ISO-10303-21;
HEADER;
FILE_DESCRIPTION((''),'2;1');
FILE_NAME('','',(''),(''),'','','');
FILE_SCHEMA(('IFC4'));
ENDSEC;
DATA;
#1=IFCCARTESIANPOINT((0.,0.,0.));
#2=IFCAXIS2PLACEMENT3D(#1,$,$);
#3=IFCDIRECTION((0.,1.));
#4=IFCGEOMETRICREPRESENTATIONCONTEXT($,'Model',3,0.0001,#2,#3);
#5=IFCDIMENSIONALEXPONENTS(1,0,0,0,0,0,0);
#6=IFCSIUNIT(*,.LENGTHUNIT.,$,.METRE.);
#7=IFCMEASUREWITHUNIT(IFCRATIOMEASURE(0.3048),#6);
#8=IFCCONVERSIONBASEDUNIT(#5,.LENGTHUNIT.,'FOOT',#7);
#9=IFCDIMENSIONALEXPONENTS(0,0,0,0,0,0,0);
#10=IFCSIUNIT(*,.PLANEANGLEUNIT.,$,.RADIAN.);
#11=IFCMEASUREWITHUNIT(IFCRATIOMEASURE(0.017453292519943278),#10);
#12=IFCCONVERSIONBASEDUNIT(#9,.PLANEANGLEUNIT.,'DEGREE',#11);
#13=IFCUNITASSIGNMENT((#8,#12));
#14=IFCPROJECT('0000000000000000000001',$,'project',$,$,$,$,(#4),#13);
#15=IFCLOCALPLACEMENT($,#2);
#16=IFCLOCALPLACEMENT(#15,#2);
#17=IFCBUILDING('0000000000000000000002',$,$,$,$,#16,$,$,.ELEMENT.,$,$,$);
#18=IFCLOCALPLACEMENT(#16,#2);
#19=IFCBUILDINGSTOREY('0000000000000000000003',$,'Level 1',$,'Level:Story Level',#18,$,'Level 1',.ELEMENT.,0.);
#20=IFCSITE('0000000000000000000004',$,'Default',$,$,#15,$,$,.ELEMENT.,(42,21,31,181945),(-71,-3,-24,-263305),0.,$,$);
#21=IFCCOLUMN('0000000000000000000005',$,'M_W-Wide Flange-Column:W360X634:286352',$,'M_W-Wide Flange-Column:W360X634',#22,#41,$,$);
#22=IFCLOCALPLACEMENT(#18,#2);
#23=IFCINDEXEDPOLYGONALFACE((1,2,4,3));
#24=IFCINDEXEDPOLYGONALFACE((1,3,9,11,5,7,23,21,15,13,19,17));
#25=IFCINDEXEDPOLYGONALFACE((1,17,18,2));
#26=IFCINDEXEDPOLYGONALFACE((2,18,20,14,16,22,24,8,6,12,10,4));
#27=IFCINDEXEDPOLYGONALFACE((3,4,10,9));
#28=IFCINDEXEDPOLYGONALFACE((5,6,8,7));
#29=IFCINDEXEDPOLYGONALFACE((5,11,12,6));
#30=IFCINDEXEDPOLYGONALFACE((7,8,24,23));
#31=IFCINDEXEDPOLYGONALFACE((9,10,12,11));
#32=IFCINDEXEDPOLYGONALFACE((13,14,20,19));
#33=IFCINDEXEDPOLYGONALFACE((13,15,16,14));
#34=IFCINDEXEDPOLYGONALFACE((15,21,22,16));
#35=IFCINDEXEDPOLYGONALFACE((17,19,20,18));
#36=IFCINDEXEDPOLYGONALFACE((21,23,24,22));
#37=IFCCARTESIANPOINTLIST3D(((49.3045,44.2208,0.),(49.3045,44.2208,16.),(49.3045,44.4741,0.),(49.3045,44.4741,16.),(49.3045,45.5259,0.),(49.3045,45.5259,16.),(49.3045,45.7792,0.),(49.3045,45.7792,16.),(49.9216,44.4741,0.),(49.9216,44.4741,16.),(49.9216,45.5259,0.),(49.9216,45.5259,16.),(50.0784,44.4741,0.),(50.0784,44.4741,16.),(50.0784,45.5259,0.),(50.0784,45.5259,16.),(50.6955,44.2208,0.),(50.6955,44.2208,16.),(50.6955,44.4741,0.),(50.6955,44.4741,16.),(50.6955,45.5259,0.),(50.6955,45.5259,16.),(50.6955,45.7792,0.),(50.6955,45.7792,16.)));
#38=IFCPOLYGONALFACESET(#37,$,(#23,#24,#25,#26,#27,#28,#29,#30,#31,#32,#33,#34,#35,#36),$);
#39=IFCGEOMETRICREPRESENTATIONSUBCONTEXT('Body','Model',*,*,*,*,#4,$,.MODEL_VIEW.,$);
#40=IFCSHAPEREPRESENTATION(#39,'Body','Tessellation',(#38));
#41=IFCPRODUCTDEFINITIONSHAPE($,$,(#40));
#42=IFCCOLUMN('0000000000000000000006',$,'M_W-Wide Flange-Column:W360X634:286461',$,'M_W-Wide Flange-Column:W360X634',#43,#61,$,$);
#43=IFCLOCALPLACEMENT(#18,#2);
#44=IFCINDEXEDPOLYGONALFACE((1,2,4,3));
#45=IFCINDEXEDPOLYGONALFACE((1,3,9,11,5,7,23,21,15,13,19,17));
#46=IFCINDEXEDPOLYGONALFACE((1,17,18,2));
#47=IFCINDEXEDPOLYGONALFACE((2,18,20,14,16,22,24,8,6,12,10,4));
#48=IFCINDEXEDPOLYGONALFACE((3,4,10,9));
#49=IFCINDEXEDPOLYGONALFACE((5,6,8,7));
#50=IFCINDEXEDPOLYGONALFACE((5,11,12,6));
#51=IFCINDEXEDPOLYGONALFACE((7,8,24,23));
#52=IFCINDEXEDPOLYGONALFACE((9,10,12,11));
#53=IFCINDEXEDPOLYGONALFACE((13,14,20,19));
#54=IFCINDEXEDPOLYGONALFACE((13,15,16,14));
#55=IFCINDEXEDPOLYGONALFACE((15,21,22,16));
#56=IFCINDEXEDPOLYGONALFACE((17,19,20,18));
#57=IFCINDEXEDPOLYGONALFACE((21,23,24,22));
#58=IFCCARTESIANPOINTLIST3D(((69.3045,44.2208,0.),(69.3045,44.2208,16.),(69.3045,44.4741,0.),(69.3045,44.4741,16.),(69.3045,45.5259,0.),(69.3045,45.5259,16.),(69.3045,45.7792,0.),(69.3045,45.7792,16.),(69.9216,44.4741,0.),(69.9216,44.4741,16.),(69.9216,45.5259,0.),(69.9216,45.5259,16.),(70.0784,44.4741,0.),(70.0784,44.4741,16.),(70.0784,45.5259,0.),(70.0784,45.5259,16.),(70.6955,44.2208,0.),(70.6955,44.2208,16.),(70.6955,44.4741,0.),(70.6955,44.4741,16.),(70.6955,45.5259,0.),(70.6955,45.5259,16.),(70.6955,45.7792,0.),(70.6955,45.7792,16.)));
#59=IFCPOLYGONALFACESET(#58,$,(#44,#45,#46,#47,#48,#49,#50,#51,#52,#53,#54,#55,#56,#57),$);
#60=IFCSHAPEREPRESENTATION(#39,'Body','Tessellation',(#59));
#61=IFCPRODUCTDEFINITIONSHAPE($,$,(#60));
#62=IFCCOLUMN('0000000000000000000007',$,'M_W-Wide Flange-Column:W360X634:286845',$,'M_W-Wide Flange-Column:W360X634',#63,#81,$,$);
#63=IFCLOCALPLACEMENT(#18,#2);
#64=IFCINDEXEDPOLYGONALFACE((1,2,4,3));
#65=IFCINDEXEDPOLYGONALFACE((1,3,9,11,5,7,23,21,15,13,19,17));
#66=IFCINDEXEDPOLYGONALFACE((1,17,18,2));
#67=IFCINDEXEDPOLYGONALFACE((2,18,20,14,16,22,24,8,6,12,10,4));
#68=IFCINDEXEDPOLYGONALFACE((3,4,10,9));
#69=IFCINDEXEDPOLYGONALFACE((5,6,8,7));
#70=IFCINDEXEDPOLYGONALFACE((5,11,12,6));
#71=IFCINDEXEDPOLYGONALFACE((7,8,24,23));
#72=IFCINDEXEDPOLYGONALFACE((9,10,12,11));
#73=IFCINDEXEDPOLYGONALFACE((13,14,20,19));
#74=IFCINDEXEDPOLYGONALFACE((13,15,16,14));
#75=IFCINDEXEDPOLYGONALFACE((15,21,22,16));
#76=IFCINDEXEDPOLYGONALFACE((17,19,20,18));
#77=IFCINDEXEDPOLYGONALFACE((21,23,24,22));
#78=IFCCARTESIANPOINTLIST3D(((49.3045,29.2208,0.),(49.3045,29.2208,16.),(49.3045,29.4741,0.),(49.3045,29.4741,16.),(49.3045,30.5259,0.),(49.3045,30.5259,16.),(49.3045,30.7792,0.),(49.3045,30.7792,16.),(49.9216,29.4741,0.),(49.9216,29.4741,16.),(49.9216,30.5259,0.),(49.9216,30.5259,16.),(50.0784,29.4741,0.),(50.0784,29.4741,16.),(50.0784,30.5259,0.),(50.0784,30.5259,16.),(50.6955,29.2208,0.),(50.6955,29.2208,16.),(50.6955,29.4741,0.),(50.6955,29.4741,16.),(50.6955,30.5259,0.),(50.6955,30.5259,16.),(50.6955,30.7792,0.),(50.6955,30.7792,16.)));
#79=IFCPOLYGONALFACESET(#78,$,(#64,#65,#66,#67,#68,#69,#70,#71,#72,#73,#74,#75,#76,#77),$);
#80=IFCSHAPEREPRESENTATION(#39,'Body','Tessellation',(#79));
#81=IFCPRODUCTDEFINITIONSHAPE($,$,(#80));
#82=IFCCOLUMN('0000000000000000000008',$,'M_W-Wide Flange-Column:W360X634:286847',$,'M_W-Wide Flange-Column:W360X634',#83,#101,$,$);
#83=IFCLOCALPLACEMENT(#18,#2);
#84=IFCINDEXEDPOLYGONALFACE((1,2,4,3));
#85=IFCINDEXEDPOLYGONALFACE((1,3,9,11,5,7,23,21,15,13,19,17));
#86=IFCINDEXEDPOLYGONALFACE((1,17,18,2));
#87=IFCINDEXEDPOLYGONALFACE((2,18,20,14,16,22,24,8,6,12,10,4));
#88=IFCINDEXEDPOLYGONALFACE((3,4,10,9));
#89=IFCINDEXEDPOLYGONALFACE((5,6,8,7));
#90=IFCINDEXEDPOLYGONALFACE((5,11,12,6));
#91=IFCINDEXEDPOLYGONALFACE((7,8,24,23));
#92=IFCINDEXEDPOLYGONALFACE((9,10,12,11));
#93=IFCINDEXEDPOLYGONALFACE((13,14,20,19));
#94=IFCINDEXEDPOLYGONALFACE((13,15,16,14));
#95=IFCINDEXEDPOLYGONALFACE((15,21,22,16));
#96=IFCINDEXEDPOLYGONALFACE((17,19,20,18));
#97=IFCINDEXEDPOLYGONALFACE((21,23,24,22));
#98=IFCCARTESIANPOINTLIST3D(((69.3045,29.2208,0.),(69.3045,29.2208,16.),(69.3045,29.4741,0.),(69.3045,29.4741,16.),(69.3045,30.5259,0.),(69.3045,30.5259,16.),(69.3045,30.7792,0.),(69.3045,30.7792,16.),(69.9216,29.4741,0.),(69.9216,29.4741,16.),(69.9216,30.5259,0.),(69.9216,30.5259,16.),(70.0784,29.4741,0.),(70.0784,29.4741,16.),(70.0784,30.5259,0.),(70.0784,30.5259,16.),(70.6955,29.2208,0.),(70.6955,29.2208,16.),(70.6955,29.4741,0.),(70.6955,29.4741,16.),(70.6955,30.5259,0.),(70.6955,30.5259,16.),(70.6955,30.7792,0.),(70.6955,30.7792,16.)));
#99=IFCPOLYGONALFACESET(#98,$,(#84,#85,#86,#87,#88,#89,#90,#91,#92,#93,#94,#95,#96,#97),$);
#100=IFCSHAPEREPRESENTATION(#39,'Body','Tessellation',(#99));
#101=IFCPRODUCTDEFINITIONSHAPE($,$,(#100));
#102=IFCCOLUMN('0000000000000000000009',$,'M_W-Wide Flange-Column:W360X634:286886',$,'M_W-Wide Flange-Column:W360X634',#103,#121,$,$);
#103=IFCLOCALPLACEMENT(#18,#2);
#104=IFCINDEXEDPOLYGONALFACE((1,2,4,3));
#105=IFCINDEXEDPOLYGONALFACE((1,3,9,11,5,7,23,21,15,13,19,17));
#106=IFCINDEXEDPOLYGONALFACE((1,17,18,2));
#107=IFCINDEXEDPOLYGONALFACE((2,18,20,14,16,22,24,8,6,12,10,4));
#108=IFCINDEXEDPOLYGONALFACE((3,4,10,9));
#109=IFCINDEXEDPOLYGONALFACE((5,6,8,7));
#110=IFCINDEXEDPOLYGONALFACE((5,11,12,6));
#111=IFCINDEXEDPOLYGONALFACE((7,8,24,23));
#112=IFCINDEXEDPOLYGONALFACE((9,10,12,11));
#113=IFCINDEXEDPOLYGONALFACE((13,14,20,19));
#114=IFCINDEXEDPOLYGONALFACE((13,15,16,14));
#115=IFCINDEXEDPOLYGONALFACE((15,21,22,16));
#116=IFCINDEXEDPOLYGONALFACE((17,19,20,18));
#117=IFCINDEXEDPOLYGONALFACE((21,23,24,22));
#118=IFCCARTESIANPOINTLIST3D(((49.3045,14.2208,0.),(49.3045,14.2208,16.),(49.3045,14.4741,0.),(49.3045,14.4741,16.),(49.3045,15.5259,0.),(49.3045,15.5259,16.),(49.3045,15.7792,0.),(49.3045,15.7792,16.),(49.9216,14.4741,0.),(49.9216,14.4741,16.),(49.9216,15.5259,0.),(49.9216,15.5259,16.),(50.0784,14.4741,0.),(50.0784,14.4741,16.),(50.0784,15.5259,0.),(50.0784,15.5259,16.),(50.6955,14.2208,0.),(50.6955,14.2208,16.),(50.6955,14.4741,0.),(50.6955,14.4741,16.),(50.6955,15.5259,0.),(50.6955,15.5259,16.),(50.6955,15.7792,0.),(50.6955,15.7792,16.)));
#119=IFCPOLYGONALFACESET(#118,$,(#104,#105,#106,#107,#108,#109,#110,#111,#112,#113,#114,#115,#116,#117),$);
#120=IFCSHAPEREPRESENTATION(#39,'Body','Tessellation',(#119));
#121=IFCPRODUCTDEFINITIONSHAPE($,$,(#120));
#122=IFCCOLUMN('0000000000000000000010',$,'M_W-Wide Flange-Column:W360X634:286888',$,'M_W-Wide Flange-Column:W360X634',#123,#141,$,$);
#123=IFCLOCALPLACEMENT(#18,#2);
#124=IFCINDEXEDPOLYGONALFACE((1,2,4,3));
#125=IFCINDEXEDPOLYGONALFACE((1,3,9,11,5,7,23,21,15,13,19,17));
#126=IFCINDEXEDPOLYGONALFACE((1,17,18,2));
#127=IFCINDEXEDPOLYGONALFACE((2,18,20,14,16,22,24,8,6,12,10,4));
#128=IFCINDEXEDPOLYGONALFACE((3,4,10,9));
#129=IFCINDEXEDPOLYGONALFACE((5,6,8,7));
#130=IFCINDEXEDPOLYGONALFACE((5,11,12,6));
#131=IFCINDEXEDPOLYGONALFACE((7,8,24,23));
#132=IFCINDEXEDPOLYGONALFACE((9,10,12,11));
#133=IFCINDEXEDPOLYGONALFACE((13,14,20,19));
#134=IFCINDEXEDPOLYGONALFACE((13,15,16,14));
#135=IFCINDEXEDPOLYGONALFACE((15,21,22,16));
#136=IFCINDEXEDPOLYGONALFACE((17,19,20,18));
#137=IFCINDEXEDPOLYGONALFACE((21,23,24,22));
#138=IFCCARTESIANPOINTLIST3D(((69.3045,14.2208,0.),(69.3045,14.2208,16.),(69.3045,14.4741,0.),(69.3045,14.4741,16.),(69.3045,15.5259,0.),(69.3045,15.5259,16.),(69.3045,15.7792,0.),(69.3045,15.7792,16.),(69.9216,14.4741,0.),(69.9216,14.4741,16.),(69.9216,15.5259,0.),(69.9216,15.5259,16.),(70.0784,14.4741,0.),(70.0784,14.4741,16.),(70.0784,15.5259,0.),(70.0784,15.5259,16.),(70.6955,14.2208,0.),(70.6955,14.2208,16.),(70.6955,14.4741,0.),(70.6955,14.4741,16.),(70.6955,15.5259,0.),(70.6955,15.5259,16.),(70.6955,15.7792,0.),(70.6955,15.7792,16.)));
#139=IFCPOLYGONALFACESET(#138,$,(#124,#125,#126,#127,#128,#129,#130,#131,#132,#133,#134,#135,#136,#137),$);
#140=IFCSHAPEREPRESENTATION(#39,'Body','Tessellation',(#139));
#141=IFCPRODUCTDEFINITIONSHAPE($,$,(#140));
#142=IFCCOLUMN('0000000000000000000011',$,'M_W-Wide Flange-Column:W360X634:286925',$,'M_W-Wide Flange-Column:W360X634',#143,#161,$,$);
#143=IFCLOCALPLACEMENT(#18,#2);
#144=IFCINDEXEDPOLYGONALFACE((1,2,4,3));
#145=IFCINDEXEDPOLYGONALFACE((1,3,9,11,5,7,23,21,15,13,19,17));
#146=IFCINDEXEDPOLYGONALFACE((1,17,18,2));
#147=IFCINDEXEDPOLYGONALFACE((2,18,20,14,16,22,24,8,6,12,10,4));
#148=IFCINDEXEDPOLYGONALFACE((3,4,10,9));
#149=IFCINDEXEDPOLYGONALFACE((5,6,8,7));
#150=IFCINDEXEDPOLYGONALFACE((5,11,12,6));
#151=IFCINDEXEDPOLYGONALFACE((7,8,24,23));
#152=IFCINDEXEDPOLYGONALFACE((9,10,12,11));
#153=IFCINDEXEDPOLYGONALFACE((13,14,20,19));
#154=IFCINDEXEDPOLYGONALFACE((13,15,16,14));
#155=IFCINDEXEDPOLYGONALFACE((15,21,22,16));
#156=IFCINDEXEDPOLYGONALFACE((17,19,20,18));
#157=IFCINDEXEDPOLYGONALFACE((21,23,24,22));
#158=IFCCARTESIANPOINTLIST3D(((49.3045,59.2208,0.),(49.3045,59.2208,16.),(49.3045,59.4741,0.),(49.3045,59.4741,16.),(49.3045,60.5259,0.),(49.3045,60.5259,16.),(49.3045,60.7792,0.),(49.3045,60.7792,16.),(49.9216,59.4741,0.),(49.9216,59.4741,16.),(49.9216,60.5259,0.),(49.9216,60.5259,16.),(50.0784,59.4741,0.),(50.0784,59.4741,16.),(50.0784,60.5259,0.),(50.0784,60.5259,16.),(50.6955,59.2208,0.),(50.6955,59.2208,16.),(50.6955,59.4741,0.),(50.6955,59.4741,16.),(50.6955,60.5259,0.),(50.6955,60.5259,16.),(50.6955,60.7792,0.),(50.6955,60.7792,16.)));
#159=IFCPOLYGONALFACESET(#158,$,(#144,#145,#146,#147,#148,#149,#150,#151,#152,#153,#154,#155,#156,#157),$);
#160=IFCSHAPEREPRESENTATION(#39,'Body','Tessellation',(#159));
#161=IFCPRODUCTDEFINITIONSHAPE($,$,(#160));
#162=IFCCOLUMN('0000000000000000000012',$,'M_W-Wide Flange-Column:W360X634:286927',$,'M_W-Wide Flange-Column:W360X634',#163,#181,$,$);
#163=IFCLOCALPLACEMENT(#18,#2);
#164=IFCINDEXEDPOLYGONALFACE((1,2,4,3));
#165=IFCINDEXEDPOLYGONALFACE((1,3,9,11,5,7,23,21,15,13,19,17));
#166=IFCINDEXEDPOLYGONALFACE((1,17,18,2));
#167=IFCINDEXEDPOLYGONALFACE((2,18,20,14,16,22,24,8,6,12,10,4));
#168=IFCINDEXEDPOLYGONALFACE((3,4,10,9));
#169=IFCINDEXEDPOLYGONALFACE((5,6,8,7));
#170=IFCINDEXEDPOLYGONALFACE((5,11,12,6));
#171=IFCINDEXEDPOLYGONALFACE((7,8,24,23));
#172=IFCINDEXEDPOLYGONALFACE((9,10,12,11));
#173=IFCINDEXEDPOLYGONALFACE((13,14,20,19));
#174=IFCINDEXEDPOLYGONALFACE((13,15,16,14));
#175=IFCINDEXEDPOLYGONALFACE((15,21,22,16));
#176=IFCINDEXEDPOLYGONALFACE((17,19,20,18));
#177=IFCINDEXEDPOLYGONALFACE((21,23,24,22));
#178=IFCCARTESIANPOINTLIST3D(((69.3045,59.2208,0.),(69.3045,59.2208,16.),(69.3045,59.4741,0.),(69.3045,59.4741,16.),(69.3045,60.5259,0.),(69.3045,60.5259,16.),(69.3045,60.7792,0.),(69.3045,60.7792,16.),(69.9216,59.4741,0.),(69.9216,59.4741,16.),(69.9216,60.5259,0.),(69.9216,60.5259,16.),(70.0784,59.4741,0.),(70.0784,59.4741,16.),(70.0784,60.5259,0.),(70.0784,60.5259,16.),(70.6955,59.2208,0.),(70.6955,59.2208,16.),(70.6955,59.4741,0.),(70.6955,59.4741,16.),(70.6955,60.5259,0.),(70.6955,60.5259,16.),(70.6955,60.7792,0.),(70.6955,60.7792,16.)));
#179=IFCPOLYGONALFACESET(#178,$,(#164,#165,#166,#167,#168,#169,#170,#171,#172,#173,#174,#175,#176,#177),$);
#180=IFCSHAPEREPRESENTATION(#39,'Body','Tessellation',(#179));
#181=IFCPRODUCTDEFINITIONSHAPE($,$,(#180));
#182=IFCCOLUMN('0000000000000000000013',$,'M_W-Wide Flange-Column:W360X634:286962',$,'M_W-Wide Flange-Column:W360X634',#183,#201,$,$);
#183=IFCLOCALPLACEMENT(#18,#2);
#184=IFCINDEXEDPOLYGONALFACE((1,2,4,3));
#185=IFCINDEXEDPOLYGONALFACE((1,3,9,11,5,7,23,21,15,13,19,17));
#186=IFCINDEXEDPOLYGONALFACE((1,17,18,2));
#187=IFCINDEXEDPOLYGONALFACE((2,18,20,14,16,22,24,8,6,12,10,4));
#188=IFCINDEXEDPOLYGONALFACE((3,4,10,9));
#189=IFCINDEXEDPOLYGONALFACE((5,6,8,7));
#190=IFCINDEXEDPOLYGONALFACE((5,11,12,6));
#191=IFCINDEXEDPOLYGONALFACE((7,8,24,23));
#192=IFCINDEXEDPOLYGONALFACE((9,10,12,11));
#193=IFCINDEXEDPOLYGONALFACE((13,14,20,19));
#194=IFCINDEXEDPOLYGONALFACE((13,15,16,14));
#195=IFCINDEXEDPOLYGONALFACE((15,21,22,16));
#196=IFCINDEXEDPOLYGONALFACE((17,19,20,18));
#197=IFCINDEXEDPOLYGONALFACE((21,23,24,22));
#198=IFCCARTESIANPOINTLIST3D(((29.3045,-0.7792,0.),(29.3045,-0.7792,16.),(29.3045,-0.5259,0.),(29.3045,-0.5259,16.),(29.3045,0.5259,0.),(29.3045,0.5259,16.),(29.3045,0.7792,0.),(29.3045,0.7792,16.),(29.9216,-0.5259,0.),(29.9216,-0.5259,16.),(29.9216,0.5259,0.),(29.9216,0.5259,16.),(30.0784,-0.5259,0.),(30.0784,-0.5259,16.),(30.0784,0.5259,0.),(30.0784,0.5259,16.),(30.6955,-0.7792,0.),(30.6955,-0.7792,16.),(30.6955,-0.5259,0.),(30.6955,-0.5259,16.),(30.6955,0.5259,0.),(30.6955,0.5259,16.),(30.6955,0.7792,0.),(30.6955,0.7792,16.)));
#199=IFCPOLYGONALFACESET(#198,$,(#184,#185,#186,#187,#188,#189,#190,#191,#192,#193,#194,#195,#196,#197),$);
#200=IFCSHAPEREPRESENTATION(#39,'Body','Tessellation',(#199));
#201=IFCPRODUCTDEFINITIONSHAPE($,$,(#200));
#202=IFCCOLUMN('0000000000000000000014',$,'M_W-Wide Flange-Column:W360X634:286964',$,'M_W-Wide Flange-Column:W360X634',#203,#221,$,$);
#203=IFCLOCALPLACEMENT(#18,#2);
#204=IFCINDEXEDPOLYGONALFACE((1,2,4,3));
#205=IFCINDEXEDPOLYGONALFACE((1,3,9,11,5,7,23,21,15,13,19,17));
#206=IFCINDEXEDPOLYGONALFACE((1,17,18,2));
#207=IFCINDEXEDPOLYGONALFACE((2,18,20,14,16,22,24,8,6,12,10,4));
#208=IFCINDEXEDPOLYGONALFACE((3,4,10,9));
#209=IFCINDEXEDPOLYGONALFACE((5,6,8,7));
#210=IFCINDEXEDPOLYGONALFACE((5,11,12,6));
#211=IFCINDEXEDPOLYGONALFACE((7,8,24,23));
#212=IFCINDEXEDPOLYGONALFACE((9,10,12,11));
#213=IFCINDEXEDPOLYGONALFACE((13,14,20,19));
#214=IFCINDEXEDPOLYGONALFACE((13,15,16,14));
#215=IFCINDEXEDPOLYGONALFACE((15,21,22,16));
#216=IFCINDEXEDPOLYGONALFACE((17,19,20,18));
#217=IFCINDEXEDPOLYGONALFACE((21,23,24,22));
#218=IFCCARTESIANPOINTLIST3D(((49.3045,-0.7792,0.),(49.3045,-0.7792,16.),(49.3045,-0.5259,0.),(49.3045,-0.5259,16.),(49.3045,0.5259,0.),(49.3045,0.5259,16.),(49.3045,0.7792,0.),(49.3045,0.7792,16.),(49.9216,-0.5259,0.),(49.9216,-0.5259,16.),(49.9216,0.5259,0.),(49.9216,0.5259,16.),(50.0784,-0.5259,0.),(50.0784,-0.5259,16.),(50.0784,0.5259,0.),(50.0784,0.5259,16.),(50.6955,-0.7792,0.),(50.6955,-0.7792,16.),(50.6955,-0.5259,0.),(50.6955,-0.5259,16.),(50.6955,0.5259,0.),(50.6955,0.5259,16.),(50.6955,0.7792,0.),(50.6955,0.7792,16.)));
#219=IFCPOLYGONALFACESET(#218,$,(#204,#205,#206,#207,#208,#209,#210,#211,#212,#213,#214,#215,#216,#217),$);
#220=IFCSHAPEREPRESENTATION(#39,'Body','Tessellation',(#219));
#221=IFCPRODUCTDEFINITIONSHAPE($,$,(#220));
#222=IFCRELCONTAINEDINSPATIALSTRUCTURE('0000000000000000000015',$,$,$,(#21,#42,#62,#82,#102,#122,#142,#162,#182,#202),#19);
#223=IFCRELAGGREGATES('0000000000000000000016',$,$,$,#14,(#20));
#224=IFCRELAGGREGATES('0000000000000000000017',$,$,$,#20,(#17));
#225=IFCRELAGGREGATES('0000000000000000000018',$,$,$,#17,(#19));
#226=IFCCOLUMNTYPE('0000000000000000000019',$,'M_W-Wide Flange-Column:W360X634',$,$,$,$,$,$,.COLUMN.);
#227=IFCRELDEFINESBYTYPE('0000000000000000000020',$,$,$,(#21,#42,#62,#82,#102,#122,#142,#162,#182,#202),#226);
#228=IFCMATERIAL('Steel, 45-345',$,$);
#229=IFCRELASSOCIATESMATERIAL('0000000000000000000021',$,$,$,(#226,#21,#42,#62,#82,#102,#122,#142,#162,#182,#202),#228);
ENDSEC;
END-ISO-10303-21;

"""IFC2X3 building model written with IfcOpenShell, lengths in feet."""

from ifc_helpers import new_model, entity, si_unit, converted_unit, direction, frame, origin, place, context, subcontext, project, spatial, polyline, outline, extrude, source, transform, mapped, material, type_object, type_shapes, element, save


model = new_model("IFC2X3")

# Units and contexts
model_context = context("Model", 3, precision=0.0001, world=origin(), true_north=direction((0.0, 1.0)))
body_context = subcontext(model_context, "Body", "Model", "MODEL_VIEW")
ifc_project = project(units=[converted_unit("LENGTHUNIT", "FOOT", entity("IfcRatioMeasure", 0.3048), si_unit("LENGTHUNIT", "METRE"), dimensions=[1, 0, 0, 0, 0, 0, 0]), converted_unit("PLANEANGLEUNIT", "DEGREE", entity("IfcRatioMeasure", 0.017453292519943278), si_unit("PLANEANGLEUNIT", "RADIAN"), dimensions=[0, 0, 0, 0, 0, 0, 0])], contexts=[model_context])

# Site, building, storey
site_placement = place(None, origin())
site = spatial("IfcSite", under=ifc_project, at=site_placement, Name="Default", CompositionType="ELEMENT", RefLatitude=(42, 21, 31, 181945), RefLongitude=(-71, -3, -24, -263305), RefElevation=0.0)
building_placement = place(site_placement, origin())
building = spatial("IfcBuilding", under=site, at=building_placement, CompositionType="ELEMENT")
storey_placement = place(building_placement, origin())
storey = spatial("IfcBuildingStorey", under=building, at=storey_placement, Name="Level 1", ObjectType="Level:Story Level", LongName="Level 1", CompositionType="ELEMENT", Elevation=0.0)

# Columns
ifc_material = material(Name="Steel, 45-345")
column_type = type_object("IfcColumnType", Name="M_W-Wide Flange-Column:W360X634", PredefinedType="COLUMN", material=ifc_material)
shared_shape = source(origin(), body_context, "Body", "SweptSolid", [
    extrude(outline(polyline([(0.5259, -0.6955), (0.7792, -0.6955), (0.7792, 0.6955), (0.5259, 0.6955), (0.5259, 0.0784), (-0.5259, 0.0784), (-0.5259, 0.6955), (-0.7792, 0.6955), (-0.7792, -0.6955), (-0.5259, -0.6955), (-0.5259, -0.0784), (0.5259, -0.0784), (0.5259, -0.6955)])), frame((0.0, 0.0, 0.0), z_axis=(0.0, 0.0, 1.0), x_axis=(0.0, -1.0, 0.0)), (0.0, 0.0, 1.0), 16.0),
])
type_shapes(column_type, [shared_shape])
for number, where, name in (
    (1, (50.0, 45.0, 0.0), "M_W-Wide Flange-Column:W360X634:286352"),
    (2, (70.0, 45.0, 0.0), "M_W-Wide Flange-Column:W360X634:286461"),
    (3, (50.0, 30.0, 0.0), "M_W-Wide Flange-Column:W360X634:286845"),
    (4, (70.0, 30.0, 0.0), "M_W-Wide Flange-Column:W360X634:286847"),
    (5, (50.0, 15.0, 0.0), "M_W-Wide Flange-Column:W360X634:286886"),
    (6, (70.0, 15.0, 0.0), "M_W-Wide Flange-Column:W360X634:286888"),
    (7, (50.0, 60.0, 0.0), "M_W-Wide Flange-Column:W360X634:286925"),
    (8, (70.0, 60.0, 0.0), "M_W-Wide Flange-Column:W360X634:286927"),
    (9, (30.0, 0.0, 0.0), "M_W-Wide Flange-Column:W360X634:286962"),
    (10, (50.0, 0.0, 0.0), "M_W-Wide Flange-Column:W360X634:286964"),
):
    element("IfcColumn", number, at=place(storey_placement, frame(where)), inside=storey, type_object=column_type, material=ifc_material, Name=name, ObjectType="M_W-Wide Flange-Column:W360X634", context=body_context, shape_type="MappedRepresentation", body=[
        mapped(shared_shape, transform((0.0, 0.0, 0.0), scale=1.0)),
    ])

save(model, "model.ifc")
